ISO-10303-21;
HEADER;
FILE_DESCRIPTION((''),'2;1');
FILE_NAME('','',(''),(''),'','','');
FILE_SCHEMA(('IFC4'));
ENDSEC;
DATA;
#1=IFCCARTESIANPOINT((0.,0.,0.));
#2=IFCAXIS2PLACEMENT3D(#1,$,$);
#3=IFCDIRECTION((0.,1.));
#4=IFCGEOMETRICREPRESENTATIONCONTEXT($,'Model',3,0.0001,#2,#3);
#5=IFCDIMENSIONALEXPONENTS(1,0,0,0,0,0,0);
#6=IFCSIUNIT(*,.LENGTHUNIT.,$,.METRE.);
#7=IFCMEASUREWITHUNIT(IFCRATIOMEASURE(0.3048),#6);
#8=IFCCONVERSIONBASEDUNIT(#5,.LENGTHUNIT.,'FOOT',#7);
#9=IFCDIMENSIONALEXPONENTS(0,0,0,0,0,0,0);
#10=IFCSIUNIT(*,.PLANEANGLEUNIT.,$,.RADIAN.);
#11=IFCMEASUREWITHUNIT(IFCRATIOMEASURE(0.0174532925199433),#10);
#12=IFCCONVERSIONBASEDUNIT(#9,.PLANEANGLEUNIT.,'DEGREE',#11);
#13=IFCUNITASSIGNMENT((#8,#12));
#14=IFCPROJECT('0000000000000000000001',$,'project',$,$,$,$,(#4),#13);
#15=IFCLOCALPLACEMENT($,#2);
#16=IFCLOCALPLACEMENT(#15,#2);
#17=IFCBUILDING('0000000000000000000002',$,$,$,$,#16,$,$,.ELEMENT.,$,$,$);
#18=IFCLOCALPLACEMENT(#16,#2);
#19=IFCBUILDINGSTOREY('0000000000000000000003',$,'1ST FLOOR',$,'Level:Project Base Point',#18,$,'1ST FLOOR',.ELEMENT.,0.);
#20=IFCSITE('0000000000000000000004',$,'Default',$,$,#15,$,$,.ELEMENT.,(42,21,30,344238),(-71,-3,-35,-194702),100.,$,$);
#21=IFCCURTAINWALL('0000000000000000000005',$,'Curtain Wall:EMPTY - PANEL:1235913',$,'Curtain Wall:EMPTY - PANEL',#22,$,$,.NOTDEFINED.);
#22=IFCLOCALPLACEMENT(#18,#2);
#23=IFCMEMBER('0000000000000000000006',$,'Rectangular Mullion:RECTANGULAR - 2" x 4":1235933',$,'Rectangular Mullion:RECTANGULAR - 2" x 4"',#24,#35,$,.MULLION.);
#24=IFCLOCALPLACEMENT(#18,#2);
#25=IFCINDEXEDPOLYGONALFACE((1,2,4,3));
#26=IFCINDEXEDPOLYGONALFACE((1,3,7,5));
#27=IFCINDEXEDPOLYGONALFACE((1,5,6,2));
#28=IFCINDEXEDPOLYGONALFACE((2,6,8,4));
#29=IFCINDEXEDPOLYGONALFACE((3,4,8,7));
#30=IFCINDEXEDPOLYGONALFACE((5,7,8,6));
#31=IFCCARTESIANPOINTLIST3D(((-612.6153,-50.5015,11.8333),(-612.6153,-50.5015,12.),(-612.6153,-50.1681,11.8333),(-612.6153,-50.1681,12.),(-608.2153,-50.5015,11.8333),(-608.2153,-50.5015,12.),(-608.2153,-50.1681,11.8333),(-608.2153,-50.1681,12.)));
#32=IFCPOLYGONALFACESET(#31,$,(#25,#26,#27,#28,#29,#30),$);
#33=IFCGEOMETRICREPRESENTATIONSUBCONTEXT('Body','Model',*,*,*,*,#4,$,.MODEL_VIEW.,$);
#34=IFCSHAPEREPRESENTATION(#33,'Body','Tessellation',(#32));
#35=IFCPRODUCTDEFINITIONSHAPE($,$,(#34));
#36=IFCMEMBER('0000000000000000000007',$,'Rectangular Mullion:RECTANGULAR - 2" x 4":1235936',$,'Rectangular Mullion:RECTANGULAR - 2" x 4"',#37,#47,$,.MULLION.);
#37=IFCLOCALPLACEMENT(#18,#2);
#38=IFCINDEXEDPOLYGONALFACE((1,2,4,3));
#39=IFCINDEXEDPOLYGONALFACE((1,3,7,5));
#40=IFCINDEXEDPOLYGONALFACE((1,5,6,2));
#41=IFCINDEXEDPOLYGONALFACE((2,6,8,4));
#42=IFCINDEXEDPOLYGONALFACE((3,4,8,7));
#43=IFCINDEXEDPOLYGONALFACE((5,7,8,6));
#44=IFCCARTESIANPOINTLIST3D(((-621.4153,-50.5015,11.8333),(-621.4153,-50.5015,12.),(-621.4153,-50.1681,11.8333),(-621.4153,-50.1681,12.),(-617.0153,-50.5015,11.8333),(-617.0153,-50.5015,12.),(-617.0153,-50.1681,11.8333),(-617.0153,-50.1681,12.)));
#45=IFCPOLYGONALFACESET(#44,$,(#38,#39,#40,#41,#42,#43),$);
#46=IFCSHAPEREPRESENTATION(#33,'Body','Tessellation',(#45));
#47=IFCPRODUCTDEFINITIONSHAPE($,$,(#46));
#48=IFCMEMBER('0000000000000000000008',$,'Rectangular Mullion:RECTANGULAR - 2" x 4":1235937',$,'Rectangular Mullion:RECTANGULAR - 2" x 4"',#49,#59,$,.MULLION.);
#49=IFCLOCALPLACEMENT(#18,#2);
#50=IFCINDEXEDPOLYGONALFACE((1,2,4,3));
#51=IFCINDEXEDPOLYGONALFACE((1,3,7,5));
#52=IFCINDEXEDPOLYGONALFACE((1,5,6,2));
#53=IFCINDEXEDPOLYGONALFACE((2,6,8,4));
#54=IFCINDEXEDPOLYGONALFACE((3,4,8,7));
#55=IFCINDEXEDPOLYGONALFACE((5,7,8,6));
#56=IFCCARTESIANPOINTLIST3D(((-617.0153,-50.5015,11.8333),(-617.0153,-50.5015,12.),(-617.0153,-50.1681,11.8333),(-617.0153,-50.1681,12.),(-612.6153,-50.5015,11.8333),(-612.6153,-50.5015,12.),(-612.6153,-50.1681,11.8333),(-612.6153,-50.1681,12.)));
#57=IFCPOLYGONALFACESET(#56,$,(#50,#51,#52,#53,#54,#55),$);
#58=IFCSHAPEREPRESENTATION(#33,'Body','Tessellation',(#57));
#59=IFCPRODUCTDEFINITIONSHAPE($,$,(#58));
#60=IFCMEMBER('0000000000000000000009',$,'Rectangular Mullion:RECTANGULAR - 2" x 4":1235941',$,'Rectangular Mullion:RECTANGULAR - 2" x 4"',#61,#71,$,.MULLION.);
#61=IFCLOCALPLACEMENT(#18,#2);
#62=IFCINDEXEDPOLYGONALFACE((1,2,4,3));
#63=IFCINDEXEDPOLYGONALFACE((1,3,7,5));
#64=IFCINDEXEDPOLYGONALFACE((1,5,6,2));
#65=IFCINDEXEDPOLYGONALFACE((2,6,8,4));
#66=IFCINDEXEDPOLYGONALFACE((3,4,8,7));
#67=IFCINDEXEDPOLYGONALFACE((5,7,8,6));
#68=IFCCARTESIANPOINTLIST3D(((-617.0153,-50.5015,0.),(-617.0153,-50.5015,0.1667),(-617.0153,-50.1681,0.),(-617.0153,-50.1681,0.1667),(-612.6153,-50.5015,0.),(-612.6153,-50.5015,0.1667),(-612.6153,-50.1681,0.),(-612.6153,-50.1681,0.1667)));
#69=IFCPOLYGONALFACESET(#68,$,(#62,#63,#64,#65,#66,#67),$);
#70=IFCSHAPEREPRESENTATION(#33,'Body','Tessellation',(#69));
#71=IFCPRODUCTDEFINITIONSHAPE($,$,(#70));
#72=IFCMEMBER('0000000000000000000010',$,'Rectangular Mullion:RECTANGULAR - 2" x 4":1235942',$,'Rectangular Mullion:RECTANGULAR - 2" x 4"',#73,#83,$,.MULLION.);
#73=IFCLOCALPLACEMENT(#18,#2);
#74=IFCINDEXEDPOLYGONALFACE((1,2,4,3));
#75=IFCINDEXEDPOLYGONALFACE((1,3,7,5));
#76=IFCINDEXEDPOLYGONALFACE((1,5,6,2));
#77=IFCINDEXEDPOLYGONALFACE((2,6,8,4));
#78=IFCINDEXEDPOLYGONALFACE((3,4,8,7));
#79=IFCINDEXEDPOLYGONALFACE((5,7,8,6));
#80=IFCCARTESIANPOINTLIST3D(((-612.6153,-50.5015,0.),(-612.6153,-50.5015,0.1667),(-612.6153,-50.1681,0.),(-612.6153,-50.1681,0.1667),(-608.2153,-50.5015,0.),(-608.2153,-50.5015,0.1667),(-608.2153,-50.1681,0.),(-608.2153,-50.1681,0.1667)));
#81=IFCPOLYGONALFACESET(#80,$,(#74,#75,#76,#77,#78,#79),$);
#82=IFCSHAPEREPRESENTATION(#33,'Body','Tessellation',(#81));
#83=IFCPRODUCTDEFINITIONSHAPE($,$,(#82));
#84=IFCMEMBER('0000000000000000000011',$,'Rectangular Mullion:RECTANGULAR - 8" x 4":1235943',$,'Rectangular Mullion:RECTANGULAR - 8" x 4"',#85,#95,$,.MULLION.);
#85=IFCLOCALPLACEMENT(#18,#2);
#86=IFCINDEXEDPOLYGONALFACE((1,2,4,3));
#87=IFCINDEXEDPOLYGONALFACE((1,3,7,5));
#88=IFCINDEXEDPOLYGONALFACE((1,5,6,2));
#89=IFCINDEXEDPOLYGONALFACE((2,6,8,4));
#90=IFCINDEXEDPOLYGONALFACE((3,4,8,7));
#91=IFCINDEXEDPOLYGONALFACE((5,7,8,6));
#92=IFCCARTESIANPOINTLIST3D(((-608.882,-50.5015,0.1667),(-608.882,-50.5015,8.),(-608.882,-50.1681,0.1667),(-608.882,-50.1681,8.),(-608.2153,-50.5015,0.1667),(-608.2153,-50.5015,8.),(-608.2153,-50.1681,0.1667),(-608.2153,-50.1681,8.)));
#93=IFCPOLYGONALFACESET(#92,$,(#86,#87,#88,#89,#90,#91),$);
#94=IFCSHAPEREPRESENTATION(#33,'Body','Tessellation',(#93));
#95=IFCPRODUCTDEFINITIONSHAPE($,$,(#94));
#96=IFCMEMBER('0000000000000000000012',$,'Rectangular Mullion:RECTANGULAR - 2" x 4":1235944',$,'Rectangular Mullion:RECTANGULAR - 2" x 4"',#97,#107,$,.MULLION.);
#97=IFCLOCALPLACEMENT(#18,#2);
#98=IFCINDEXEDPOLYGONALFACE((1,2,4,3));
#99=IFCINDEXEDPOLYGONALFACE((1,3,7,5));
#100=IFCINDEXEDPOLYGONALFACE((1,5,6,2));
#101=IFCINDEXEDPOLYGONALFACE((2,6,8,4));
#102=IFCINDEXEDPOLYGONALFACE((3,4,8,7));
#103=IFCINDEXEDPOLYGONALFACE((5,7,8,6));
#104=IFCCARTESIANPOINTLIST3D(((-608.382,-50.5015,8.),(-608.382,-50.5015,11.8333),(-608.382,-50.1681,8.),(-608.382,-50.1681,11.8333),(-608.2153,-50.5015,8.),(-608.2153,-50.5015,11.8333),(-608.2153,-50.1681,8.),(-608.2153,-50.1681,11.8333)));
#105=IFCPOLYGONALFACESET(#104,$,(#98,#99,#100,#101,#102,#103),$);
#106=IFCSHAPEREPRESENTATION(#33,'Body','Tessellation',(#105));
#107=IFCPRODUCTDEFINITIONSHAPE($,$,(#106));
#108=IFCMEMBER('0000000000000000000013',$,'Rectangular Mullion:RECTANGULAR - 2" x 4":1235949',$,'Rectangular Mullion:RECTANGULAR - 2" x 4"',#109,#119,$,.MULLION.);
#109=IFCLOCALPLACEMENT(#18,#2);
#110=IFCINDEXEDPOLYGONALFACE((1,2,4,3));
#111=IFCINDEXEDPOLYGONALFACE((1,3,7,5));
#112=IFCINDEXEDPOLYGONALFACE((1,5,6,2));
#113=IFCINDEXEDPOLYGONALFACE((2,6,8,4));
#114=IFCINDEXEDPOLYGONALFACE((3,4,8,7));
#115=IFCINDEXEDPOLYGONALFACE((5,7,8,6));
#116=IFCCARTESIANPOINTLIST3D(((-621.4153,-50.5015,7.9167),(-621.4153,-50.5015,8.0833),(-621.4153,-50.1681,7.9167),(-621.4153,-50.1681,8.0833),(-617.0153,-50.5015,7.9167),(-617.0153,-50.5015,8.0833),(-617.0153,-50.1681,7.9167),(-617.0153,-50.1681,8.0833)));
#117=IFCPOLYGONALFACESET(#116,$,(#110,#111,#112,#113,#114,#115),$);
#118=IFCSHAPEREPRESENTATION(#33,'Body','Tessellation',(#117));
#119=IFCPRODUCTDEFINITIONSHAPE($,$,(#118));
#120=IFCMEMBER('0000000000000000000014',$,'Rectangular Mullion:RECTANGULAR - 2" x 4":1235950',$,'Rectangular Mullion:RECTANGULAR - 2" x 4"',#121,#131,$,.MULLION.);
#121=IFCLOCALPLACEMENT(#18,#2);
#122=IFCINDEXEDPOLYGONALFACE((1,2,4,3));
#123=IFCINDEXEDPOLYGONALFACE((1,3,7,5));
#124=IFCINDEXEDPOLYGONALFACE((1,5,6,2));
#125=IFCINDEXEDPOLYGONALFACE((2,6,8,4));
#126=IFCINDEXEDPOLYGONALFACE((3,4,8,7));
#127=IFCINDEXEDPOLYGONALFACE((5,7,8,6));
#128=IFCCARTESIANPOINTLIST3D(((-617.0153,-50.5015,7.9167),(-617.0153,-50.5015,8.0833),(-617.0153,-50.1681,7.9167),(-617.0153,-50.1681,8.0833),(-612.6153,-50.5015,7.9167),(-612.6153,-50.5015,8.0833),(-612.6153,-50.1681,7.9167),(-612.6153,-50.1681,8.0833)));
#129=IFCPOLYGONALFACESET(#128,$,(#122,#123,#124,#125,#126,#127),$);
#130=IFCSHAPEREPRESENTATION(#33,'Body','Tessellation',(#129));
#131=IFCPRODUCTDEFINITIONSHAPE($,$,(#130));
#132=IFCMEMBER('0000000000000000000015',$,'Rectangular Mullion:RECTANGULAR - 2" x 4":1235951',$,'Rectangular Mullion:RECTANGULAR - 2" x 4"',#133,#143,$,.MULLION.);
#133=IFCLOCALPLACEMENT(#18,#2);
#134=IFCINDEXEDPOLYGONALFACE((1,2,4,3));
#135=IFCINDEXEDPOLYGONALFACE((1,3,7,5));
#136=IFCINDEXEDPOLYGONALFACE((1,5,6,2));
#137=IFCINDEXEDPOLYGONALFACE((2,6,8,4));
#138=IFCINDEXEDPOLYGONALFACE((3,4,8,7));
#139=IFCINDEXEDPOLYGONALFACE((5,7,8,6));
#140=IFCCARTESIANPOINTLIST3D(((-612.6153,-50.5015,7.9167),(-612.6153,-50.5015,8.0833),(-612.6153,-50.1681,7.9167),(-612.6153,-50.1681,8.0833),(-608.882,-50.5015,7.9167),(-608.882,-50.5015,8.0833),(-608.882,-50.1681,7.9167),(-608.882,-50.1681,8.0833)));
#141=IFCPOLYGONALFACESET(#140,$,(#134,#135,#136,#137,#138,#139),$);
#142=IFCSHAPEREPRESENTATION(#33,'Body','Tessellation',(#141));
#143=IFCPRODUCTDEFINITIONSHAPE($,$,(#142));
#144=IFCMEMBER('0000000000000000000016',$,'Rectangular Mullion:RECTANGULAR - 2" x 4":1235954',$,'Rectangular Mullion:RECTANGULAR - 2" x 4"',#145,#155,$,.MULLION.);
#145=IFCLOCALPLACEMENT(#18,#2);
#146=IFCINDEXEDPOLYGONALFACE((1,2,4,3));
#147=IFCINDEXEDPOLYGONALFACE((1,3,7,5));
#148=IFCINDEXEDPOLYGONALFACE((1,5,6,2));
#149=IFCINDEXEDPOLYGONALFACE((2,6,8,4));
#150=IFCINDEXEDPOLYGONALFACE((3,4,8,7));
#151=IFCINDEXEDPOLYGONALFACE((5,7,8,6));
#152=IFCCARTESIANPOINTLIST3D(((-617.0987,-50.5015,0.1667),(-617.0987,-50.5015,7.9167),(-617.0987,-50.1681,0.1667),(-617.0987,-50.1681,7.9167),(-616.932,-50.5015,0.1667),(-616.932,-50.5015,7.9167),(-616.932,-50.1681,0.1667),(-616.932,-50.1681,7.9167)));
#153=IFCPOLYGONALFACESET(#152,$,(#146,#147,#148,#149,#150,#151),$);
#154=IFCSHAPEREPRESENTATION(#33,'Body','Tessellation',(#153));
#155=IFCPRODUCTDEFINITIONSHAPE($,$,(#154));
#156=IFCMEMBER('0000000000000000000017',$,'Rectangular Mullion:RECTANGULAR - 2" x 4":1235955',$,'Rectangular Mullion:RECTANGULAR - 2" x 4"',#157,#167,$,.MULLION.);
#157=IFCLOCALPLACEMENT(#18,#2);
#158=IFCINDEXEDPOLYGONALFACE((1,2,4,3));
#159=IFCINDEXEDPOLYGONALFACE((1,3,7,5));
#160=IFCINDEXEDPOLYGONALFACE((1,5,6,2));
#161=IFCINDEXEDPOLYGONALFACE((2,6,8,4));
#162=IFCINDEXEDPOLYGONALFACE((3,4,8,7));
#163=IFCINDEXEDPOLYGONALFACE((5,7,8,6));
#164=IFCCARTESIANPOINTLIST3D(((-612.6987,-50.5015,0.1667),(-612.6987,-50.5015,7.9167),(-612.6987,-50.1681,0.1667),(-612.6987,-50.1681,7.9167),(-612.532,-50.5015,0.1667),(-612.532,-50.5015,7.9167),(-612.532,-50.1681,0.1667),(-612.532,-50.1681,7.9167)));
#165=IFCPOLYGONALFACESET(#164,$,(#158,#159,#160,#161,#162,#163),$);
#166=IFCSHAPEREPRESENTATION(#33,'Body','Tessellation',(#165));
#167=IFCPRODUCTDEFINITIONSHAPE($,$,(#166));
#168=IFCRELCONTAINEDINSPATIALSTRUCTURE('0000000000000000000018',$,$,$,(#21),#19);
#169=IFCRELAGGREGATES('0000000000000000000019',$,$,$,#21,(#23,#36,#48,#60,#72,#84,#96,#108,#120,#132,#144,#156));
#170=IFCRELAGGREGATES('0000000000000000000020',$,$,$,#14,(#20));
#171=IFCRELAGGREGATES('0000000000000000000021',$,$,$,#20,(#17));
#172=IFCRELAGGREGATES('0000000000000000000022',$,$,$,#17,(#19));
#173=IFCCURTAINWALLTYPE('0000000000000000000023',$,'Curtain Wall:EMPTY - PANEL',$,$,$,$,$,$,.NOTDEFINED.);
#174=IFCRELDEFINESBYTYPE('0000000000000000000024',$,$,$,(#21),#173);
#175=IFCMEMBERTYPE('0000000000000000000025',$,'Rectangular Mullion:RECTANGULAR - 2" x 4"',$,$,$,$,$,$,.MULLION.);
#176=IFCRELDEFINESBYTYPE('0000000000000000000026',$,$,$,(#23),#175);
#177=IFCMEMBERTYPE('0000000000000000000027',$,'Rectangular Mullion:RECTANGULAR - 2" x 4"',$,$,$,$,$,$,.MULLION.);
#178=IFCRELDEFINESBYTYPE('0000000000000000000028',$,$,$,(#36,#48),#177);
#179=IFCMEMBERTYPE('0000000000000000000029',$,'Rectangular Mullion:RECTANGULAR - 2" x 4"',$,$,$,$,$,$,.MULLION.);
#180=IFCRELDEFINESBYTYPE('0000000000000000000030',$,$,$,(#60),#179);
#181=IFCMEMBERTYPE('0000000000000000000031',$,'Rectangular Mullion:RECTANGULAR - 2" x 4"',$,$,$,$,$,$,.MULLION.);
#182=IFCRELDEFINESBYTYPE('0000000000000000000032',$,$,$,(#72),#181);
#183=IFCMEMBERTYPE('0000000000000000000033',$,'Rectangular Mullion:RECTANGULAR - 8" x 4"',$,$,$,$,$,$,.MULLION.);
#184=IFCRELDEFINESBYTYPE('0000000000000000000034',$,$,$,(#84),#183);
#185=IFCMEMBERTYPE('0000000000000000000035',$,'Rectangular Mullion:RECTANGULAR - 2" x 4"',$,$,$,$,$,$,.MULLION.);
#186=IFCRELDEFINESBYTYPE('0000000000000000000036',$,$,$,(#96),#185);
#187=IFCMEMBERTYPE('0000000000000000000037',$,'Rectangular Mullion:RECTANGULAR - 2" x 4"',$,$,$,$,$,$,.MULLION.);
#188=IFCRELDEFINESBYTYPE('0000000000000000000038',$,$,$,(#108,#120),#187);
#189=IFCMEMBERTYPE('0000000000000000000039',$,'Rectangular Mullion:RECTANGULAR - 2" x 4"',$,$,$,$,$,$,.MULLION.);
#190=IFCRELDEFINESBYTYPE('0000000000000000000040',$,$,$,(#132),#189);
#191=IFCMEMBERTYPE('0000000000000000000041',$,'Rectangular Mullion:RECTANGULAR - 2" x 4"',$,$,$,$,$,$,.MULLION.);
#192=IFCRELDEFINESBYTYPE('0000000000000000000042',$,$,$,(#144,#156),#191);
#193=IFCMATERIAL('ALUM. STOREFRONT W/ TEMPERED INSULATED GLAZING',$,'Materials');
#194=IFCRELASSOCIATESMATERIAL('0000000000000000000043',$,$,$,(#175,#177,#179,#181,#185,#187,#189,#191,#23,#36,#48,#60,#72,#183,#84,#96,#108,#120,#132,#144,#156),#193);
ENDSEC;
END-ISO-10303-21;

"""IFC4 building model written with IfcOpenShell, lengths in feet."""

from ifc_helpers import new_model, entity, si_unit, converted_unit, direction, frame, origin, origin_2d_with_axis, place, context, subcontext, project, spatial, rectangle, extrude, source, transform, mapped, material, material_profile, profile_set, profile_usage, type_object, type_shapes, element, aggregate, save


model = new_model("IFC4")

# Units and contexts
model_context = context("Model", 3, precision=0.0001, world=origin(), true_north=direction((0.0, 1.0)))
body_context = subcontext(model_context, "Body", "Model", "MODEL_VIEW")
ifc_project = project(units=[converted_unit("LENGTHUNIT", "FOOT", entity("IfcRatioMeasure", 0.3048), si_unit("LENGTHUNIT", "METRE"), dimensions=[1, 0, 0, 0, 0, 0, 0]), converted_unit("PLANEANGLEUNIT", "DEGREE", entity("IfcRatioMeasure", 0.0174532925199433), si_unit("PLANEANGLEUNIT", "RADIAN"), dimensions=[0, 0, 0, 0, 0, 0, 0])], contexts=[model_context])

# Site, building, storey
site_placement = place(None, origin())
site = spatial("IfcSite", under=ifc_project, at=site_placement, Name="Default", CompositionType="ELEMENT", RefLatitude=(42, 21, 30, 344238), RefLongitude=(-71, -3, -35, -194702), RefElevation=100.0)
building_placement = place(site_placement, origin())
building = spatial("IfcBuilding", under=site, at=building_placement, CompositionType="ELEMENT")
storey_placement = place(building_placement, origin())
storey = spatial("IfcBuildingStorey", under=building, at=storey_placement, Name="1ST FLOOR", ObjectType="Level:Project Base Point", LongName="1ST FLOOR", CompositionType="ELEMENT", Elevation=0.0)

# Curtain wall, members
curtain_wall_type_1 = type_object("IfcCurtainWallType", Name="Curtain Wall:EMPTY - PANEL", PredefinedType="NOTDEFINED")
curtain_wall_1_placement = place(storey_placement, origin())
curtain_wall_1 = element("IfcCurtainWall", 1, at=curtain_wall_1_placement, inside=storey, type_object=curtain_wall_type_1, Name="Curtain Wall:EMPTY - PANEL:1235913", ObjectType="Curtain Wall:EMPTY - PANEL", PredefinedType="NOTDEFINED")
ifc_material_1 = material(Name="ALUM. STOREFRONT W/ TEMPERED INSULATED GLAZING", Category="Materials")
ifc_material_profile_1 = material_profile(ifc_material_1, rectangle(XDim=0.3333, YDim=0.1667, at=origin_2d_with_axis()), Name="RECTANGULAR - 2\" x 4\"")
ifc_profile_set_1 = profile_set([ifc_material_profile_1], Name="RECTANGULAR - 2\" x 4\"")
ifc_profile_usage_1 = profile_usage(ifc_profile_set_1)
member_type_1 = type_object("IfcMemberType", Name="Rectangular Mullion:RECTANGULAR - 2\" x 4\"", PredefinedType="MULLION", material=ifc_profile_set_1)
shared_shape_1 = source(origin(), body_context, "Body", "SweptSolid", [
    extrude(rectangle(XDim=0.3333, YDim=0.1667, at=origin_2d_with_axis()), frame((-0.0833, 0.0, -4.4), z_axis=(0.0, 0.0, 1.0), x_axis=(0.0, -1.0, 0.0)), (0.0, 0.0, 1.0), 4.4),
])
type_shapes(member_type_1, [shared_shape_1])
member_1_placement = place(storey_placement, frame((-608.2153, -50.3348, 12.0), z_axis=(1.0, 0.0, 0.0), x_axis=(0.0, 0.0, 1.0)))
member_1 = element("IfcMember", 2, at=member_1_placement, type_object=member_type_1, material=ifc_profile_usage_1, Name="Rectangular Mullion:RECTANGULAR - 2\" x 4\":1235933", ObjectType="Rectangular Mullion:RECTANGULAR - 2\" x 4\"", PredefinedType="MULLION", context=body_context, shape_type="MappedRepresentation", body=[
    mapped(shared_shape_1, transform((0.0, 0.0, 0.0), scale=1.0)),
])
ifc_profile_usage_2 = profile_usage(ifc_profile_set_1)
member_type_2 = type_object("IfcMemberType", Name="Rectangular Mullion:RECTANGULAR - 2\" x 4\"", PredefinedType="MULLION", material=ifc_profile_set_1)
shared_shape_2 = source(origin(), body_context, "Body", "SweptSolid", [
    extrude(rectangle(XDim=0.3333, YDim=0.1667, at=origin_2d_with_axis()), frame((-0.0833, 0.0, -4.4), z_axis=(0.0, 0.0, 1.0), x_axis=(0.0, -1.0, 0.0)), (0.0, 0.0, 1.0), 4.4),
])
type_shapes(member_type_2, [shared_shape_2])
member_2_placement = place(storey_placement, frame((-617.0153, -50.3348, 12.0), z_axis=(1.0, 0.0, 0.0), x_axis=(0.0, 0.0, 1.0)))
member_2 = element("IfcMember", 3, at=member_2_placement, type_object=member_type_2, material=ifc_profile_usage_2, Name="Rectangular Mullion:RECTANGULAR - 2\" x 4\":1235936", ObjectType="Rectangular Mullion:RECTANGULAR - 2\" x 4\"", PredefinedType="MULLION", context=body_context, shape_type="MappedRepresentation", body=[
    mapped(shared_shape_2, transform((0.0, 0.0, 0.0), scale=1.0)),
])
ifc_profile_usage_3 = profile_usage(ifc_profile_set_1)
member_3_placement = place(storey_placement, frame((-612.6153, -50.3348, 12.0), z_axis=(1.0, 0.0, 0.0), x_axis=(0.0, 0.0, 1.0)))
member_3 = element("IfcMember", 4, at=member_3_placement, type_object=member_type_2, material=ifc_profile_usage_3, Name="Rectangular Mullion:RECTANGULAR - 2\" x 4\":1235937", ObjectType="Rectangular Mullion:RECTANGULAR - 2\" x 4\"", PredefinedType="MULLION", context=body_context, shape_type="MappedRepresentation", body=[
    mapped(shared_shape_2, transform((0.0, 0.0, 0.0), scale=1.0)),
])
ifc_profile_usage_4 = profile_usage(ifc_profile_set_1)
member_type_3 = type_object("IfcMemberType", Name="Rectangular Mullion:RECTANGULAR - 2\" x 4\"", PredefinedType="MULLION", material=ifc_profile_set_1)
shared_shape_3 = source(origin(), body_context, "Body", "SweptSolid", [
    extrude(rectangle(XDim=0.3333, YDim=0.1667, at=origin_2d_with_axis()), frame((-0.0833, 0.0, -4.4), z_axis=(0.0, 0.0, 1.0), x_axis=(0.0, -1.0, 0.0)), (0.0, 0.0, 1.0), 4.4),
])
type_shapes(member_type_3, [shared_shape_3])
member_4_placement = place(storey_placement, frame((-617.0153, -50.3348, 0.0), z_axis=(-1.0, 0.0, 0.0), x_axis=(0.0, 0.0, -1.0)))
member_4 = element("IfcMember", 5, at=member_4_placement, type_object=member_type_3, material=ifc_profile_usage_4, Name="Rectangular Mullion:RECTANGULAR - 2\" x 4\":1235941", ObjectType="Rectangular Mullion:RECTANGULAR - 2\" x 4\"", PredefinedType="MULLION", context=body_context, shape_type="MappedRepresentation", body=[
    mapped(shared_shape_3, transform((0.0, 0.0, 0.0), scale=1.0)),
])
ifc_profile_usage_5 = profile_usage(ifc_profile_set_1)
member_type_4 = type_object("IfcMemberType", Name="Rectangular Mullion:RECTANGULAR - 2\" x 4\"", PredefinedType="MULLION", material=ifc_profile_set_1)
shared_shape_4 = source(origin(), body_context, "Body", "SweptSolid", [
    extrude(rectangle(XDim=0.3333, YDim=0.1667, at=origin_2d_with_axis()), frame((-0.0833, 0.0, -4.4), z_axis=(0.0, 0.0, 1.0), x_axis=(0.0, -1.0, 0.0)), (0.0, 0.0, 1.0), 4.4),
])
type_shapes(member_type_4, [shared_shape_4])
member_5_placement = place(storey_placement, frame((-612.6153, -50.3348, 0.0), z_axis=(-1.0, 0.0, 0.0), x_axis=(0.0, 0.0, -1.0)))
member_5 = element("IfcMember", 6, at=member_5_placement, type_object=member_type_4, material=ifc_profile_usage_5, Name="Rectangular Mullion:RECTANGULAR - 2\" x 4\":1235942", ObjectType="Rectangular Mullion:RECTANGULAR - 2\" x 4\"", PredefinedType="MULLION", context=body_context, shape_type="MappedRepresentation", body=[
    mapped(shared_shape_4, transform((0.0, 0.0, 0.0), scale=1.0)),
])
ifc_material_profile_2 = material_profile(ifc_material_1, rectangle(XDim=0.3333, YDim=0.6667, at=origin_2d_with_axis()), Name="RECTANGULAR - 8\" x 4\"")
ifc_profile_set_2 = profile_set([ifc_material_profile_2], Name="RECTANGULAR - 8\" x 4\"")
ifc_profile_usage_6 = profile_usage(ifc_profile_set_2)
member_type_5 = type_object("IfcMemberType", Name="Rectangular Mullion:RECTANGULAR - 8\" x 4\"", PredefinedType="MULLION", material=ifc_profile_set_2)
shared_shape_5 = source(origin(), body_context, "Body", "SweptSolid", [
    extrude(rectangle(XDim=0.3333, YDim=0.6667, at=origin_2d_with_axis()), frame((-0.3333, 0.0, -7.8333), z_axis=(0.0, 0.0, 1.0), x_axis=(0.0, -1.0, 0.0)), (0.0, 0.0, 1.0), 7.8333),
])
type_shapes(member_type_5, [shared_shape_5])
member_6_placement = place(storey_placement, frame((-608.2153, -50.3348, 0.1667), z_axis=(0.0, 0.0, -1.0), x_axis=(1.0, 0.0, 0.0)))
member_6 = element("IfcMember", 7, at=member_6_placement, type_object=member_type_5, material=ifc_profile_usage_6, Name="Rectangular Mullion:RECTANGULAR - 8\" x 4\":1235943", ObjectType="Rectangular Mullion:RECTANGULAR - 8\" x 4\"", PredefinedType="MULLION", context=body_context, shape_type="MappedRepresentation", body=[
    mapped(shared_shape_5, transform((0.0, 0.0, 0.0), scale=1.0)),
])
ifc_profile_usage_7 = profile_usage(ifc_profile_set_1)
member_type_6 = type_object("IfcMemberType", Name="Rectangular Mullion:RECTANGULAR - 2\" x 4\"", PredefinedType="MULLION", material=ifc_profile_set_1)
shared_shape_6 = source(origin(), body_context, "Body", "SweptSolid", [
    extrude(rectangle(XDim=0.3333, YDim=0.1667, at=origin_2d_with_axis()), frame((-0.0833, 0.0, -3.8333), z_axis=(0.0, 0.0, 1.0), x_axis=(0.0, -1.0, 0.0)), (0.0, 0.0, 1.0), 3.8333),
])
type_shapes(member_type_6, [shared_shape_6])
member_7_placement = place(storey_placement, frame((-608.2153, -50.3348, 8.0), z_axis=(0.0, 0.0, -1.0), x_axis=(1.0, 0.0, 0.0)))
member_7 = element("IfcMember", 8, at=member_7_placement, type_object=member_type_6, material=ifc_profile_usage_7, Name="Rectangular Mullion:RECTANGULAR - 2\" x 4\":1235944", ObjectType="Rectangular Mullion:RECTANGULAR - 2\" x 4\"", PredefinedType="MULLION", context=body_context, shape_type="MappedRepresentation", body=[
    mapped(shared_shape_6, transform((0.0, 0.0, 0.0), scale=1.0)),
])
ifc_profile_usage_8 = profile_usage(ifc_profile_set_1)
member_type_7 = type_object("IfcMemberType", Name="Rectangular Mullion:RECTANGULAR - 2\" x 4\"", PredefinedType="MULLION", material=ifc_profile_set_1)
shared_shape_7 = source(origin(), body_context, "Body", "SweptSolid", [
    extrude(rectangle(XDim=0.3333, YDim=0.1667, at=origin_2d_with_axis()), frame((0.0, 0.0, -4.4), z_axis=(0.0, 0.0, 1.0), x_axis=(0.0, -1.0, 0.0)), (0.0, 0.0, 1.0), 4.4),
])
type_shapes(member_type_7, [shared_shape_7])
member_8_placement = place(storey_placement, frame((-617.0153, -50.3348, 8.0), z_axis=(1.0, 0.0, 0.0), x_axis=(0.0, 0.0, 1.0)))
member_8 = element("IfcMember", 9, at=member_8_placement, type_object=member_type_7, material=ifc_profile_usage_8, Name="Rectangular Mullion:RECTANGULAR - 2\" x 4\":1235949", ObjectType="Rectangular Mullion:RECTANGULAR - 2\" x 4\"", PredefinedType="MULLION", context=body_context, shape_type="MappedRepresentation", body=[
    mapped(shared_shape_7, transform((0.0, 0.0, 0.0), scale=1.0)),
])
ifc_profile_usage_9 = profile_usage(ifc_profile_set_1)
member_9_placement = place(storey_placement, frame((-612.6153, -50.3348, 8.0), z_axis=(1.0, 0.0, 0.0), x_axis=(0.0, 0.0, 1.0)))
member_9 = element("IfcMember", 10, at=member_9_placement, type_object=member_type_7, material=ifc_profile_usage_9, Name="Rectangular Mullion:RECTANGULAR - 2\" x 4\":1235950", ObjectType="Rectangular Mullion:RECTANGULAR - 2\" x 4\"", PredefinedType="MULLION", context=body_context, shape_type="MappedRepresentation", body=[
    mapped(shared_shape_7, transform((0.0, 0.0, 0.0), scale=1.0)),
])
ifc_profile_usage_10 = profile_usage(ifc_profile_set_1)
member_type_8 = type_object("IfcMemberType", Name="Rectangular Mullion:RECTANGULAR - 2\" x 4\"", PredefinedType="MULLION", material=ifc_profile_set_1)
shared_shape_8 = source(origin(), body_context, "Body", "SweptSolid", [
    extrude(rectangle(XDim=0.3333, YDim=0.1667, at=origin_2d_with_axis()), frame((0.0, 0.0, -3.7333), z_axis=(0.0, 0.0, 1.0), x_axis=(0.0, -1.0, 0.0)), (0.0, 0.0, 1.0), 3.7333),
])
type_shapes(member_type_8, [shared_shape_8])
member_10_placement = place(storey_placement, frame((-608.882, -50.3348, 8.0), z_axis=(1.0, 0.0, 0.0), x_axis=(0.0, 0.0, 1.0)))
member_10 = element("IfcMember", 11, at=member_10_placement, type_object=member_type_8, material=ifc_profile_usage_10, Name="Rectangular Mullion:RECTANGULAR - 2\" x 4\":1235951", ObjectType="Rectangular Mullion:RECTANGULAR - 2\" x 4\"", PredefinedType="MULLION", context=body_context, shape_type="MappedRepresentation", body=[
    mapped(shared_shape_8, transform((0.0, 0.0, 0.0), scale=1.0)),
])
ifc_profile_usage_11 = profile_usage(ifc_profile_set_1)
member_type_9 = type_object("IfcMemberType", Name="Rectangular Mullion:RECTANGULAR - 2\" x 4\"", PredefinedType="MULLION", material=ifc_profile_set_1)
shared_shape_9 = source(origin(), body_context, "Body", "SweptSolid", [
    extrude(rectangle(XDim=0.3333, YDim=0.1667, at=origin_2d_with_axis()), frame((0.0, 0.0, -7.75), z_axis=(0.0, 0.0, 1.0), x_axis=(0.0, -1.0, 0.0)), (0.0, 0.0, 1.0), 7.75),
])
type_shapes(member_type_9, [shared_shape_9])
member_11_placement = place(storey_placement, frame((-617.0153, -50.3348, 0.1667), z_axis=(0.0, 0.0, -1.0), x_axis=(1.0, 0.0, 0.0)))
member_11 = element("IfcMember", 12, at=member_11_placement, type_object=member_type_9, material=ifc_profile_usage_11, Name="Rectangular Mullion:RECTANGULAR - 2\" x 4\":1235954", ObjectType="Rectangular Mullion:RECTANGULAR - 2\" x 4\"", PredefinedType="MULLION", context=body_context, shape_type="MappedRepresentation", body=[
    mapped(shared_shape_9, transform((0.0, 0.0, 0.0), scale=1.0)),
])
ifc_profile_usage_12 = profile_usage(ifc_profile_set_1)
member_12_placement = place(storey_placement, frame((-612.6153, -50.3348, 0.1667), z_axis=(0.0, 0.0, -1.0), x_axis=(1.0, 0.0, 0.0)))
member_12 = element("IfcMember", 13, at=member_12_placement, type_object=member_type_9, material=ifc_profile_usage_12, Name="Rectangular Mullion:RECTANGULAR - 2\" x 4\":1235955", ObjectType="Rectangular Mullion:RECTANGULAR - 2\" x 4\"", PredefinedType="MULLION", context=body_context, shape_type="MappedRepresentation", body=[
    mapped(shared_shape_9, transform((0.0, 0.0, 0.0), scale=1.0)),
])
aggregate(curtain_wall_1, [member_1, member_2, member_3, member_4, member_5, member_6, member_7, member_8, member_9, member_10, member_11, member_12])

save(model, "model.ifc")
